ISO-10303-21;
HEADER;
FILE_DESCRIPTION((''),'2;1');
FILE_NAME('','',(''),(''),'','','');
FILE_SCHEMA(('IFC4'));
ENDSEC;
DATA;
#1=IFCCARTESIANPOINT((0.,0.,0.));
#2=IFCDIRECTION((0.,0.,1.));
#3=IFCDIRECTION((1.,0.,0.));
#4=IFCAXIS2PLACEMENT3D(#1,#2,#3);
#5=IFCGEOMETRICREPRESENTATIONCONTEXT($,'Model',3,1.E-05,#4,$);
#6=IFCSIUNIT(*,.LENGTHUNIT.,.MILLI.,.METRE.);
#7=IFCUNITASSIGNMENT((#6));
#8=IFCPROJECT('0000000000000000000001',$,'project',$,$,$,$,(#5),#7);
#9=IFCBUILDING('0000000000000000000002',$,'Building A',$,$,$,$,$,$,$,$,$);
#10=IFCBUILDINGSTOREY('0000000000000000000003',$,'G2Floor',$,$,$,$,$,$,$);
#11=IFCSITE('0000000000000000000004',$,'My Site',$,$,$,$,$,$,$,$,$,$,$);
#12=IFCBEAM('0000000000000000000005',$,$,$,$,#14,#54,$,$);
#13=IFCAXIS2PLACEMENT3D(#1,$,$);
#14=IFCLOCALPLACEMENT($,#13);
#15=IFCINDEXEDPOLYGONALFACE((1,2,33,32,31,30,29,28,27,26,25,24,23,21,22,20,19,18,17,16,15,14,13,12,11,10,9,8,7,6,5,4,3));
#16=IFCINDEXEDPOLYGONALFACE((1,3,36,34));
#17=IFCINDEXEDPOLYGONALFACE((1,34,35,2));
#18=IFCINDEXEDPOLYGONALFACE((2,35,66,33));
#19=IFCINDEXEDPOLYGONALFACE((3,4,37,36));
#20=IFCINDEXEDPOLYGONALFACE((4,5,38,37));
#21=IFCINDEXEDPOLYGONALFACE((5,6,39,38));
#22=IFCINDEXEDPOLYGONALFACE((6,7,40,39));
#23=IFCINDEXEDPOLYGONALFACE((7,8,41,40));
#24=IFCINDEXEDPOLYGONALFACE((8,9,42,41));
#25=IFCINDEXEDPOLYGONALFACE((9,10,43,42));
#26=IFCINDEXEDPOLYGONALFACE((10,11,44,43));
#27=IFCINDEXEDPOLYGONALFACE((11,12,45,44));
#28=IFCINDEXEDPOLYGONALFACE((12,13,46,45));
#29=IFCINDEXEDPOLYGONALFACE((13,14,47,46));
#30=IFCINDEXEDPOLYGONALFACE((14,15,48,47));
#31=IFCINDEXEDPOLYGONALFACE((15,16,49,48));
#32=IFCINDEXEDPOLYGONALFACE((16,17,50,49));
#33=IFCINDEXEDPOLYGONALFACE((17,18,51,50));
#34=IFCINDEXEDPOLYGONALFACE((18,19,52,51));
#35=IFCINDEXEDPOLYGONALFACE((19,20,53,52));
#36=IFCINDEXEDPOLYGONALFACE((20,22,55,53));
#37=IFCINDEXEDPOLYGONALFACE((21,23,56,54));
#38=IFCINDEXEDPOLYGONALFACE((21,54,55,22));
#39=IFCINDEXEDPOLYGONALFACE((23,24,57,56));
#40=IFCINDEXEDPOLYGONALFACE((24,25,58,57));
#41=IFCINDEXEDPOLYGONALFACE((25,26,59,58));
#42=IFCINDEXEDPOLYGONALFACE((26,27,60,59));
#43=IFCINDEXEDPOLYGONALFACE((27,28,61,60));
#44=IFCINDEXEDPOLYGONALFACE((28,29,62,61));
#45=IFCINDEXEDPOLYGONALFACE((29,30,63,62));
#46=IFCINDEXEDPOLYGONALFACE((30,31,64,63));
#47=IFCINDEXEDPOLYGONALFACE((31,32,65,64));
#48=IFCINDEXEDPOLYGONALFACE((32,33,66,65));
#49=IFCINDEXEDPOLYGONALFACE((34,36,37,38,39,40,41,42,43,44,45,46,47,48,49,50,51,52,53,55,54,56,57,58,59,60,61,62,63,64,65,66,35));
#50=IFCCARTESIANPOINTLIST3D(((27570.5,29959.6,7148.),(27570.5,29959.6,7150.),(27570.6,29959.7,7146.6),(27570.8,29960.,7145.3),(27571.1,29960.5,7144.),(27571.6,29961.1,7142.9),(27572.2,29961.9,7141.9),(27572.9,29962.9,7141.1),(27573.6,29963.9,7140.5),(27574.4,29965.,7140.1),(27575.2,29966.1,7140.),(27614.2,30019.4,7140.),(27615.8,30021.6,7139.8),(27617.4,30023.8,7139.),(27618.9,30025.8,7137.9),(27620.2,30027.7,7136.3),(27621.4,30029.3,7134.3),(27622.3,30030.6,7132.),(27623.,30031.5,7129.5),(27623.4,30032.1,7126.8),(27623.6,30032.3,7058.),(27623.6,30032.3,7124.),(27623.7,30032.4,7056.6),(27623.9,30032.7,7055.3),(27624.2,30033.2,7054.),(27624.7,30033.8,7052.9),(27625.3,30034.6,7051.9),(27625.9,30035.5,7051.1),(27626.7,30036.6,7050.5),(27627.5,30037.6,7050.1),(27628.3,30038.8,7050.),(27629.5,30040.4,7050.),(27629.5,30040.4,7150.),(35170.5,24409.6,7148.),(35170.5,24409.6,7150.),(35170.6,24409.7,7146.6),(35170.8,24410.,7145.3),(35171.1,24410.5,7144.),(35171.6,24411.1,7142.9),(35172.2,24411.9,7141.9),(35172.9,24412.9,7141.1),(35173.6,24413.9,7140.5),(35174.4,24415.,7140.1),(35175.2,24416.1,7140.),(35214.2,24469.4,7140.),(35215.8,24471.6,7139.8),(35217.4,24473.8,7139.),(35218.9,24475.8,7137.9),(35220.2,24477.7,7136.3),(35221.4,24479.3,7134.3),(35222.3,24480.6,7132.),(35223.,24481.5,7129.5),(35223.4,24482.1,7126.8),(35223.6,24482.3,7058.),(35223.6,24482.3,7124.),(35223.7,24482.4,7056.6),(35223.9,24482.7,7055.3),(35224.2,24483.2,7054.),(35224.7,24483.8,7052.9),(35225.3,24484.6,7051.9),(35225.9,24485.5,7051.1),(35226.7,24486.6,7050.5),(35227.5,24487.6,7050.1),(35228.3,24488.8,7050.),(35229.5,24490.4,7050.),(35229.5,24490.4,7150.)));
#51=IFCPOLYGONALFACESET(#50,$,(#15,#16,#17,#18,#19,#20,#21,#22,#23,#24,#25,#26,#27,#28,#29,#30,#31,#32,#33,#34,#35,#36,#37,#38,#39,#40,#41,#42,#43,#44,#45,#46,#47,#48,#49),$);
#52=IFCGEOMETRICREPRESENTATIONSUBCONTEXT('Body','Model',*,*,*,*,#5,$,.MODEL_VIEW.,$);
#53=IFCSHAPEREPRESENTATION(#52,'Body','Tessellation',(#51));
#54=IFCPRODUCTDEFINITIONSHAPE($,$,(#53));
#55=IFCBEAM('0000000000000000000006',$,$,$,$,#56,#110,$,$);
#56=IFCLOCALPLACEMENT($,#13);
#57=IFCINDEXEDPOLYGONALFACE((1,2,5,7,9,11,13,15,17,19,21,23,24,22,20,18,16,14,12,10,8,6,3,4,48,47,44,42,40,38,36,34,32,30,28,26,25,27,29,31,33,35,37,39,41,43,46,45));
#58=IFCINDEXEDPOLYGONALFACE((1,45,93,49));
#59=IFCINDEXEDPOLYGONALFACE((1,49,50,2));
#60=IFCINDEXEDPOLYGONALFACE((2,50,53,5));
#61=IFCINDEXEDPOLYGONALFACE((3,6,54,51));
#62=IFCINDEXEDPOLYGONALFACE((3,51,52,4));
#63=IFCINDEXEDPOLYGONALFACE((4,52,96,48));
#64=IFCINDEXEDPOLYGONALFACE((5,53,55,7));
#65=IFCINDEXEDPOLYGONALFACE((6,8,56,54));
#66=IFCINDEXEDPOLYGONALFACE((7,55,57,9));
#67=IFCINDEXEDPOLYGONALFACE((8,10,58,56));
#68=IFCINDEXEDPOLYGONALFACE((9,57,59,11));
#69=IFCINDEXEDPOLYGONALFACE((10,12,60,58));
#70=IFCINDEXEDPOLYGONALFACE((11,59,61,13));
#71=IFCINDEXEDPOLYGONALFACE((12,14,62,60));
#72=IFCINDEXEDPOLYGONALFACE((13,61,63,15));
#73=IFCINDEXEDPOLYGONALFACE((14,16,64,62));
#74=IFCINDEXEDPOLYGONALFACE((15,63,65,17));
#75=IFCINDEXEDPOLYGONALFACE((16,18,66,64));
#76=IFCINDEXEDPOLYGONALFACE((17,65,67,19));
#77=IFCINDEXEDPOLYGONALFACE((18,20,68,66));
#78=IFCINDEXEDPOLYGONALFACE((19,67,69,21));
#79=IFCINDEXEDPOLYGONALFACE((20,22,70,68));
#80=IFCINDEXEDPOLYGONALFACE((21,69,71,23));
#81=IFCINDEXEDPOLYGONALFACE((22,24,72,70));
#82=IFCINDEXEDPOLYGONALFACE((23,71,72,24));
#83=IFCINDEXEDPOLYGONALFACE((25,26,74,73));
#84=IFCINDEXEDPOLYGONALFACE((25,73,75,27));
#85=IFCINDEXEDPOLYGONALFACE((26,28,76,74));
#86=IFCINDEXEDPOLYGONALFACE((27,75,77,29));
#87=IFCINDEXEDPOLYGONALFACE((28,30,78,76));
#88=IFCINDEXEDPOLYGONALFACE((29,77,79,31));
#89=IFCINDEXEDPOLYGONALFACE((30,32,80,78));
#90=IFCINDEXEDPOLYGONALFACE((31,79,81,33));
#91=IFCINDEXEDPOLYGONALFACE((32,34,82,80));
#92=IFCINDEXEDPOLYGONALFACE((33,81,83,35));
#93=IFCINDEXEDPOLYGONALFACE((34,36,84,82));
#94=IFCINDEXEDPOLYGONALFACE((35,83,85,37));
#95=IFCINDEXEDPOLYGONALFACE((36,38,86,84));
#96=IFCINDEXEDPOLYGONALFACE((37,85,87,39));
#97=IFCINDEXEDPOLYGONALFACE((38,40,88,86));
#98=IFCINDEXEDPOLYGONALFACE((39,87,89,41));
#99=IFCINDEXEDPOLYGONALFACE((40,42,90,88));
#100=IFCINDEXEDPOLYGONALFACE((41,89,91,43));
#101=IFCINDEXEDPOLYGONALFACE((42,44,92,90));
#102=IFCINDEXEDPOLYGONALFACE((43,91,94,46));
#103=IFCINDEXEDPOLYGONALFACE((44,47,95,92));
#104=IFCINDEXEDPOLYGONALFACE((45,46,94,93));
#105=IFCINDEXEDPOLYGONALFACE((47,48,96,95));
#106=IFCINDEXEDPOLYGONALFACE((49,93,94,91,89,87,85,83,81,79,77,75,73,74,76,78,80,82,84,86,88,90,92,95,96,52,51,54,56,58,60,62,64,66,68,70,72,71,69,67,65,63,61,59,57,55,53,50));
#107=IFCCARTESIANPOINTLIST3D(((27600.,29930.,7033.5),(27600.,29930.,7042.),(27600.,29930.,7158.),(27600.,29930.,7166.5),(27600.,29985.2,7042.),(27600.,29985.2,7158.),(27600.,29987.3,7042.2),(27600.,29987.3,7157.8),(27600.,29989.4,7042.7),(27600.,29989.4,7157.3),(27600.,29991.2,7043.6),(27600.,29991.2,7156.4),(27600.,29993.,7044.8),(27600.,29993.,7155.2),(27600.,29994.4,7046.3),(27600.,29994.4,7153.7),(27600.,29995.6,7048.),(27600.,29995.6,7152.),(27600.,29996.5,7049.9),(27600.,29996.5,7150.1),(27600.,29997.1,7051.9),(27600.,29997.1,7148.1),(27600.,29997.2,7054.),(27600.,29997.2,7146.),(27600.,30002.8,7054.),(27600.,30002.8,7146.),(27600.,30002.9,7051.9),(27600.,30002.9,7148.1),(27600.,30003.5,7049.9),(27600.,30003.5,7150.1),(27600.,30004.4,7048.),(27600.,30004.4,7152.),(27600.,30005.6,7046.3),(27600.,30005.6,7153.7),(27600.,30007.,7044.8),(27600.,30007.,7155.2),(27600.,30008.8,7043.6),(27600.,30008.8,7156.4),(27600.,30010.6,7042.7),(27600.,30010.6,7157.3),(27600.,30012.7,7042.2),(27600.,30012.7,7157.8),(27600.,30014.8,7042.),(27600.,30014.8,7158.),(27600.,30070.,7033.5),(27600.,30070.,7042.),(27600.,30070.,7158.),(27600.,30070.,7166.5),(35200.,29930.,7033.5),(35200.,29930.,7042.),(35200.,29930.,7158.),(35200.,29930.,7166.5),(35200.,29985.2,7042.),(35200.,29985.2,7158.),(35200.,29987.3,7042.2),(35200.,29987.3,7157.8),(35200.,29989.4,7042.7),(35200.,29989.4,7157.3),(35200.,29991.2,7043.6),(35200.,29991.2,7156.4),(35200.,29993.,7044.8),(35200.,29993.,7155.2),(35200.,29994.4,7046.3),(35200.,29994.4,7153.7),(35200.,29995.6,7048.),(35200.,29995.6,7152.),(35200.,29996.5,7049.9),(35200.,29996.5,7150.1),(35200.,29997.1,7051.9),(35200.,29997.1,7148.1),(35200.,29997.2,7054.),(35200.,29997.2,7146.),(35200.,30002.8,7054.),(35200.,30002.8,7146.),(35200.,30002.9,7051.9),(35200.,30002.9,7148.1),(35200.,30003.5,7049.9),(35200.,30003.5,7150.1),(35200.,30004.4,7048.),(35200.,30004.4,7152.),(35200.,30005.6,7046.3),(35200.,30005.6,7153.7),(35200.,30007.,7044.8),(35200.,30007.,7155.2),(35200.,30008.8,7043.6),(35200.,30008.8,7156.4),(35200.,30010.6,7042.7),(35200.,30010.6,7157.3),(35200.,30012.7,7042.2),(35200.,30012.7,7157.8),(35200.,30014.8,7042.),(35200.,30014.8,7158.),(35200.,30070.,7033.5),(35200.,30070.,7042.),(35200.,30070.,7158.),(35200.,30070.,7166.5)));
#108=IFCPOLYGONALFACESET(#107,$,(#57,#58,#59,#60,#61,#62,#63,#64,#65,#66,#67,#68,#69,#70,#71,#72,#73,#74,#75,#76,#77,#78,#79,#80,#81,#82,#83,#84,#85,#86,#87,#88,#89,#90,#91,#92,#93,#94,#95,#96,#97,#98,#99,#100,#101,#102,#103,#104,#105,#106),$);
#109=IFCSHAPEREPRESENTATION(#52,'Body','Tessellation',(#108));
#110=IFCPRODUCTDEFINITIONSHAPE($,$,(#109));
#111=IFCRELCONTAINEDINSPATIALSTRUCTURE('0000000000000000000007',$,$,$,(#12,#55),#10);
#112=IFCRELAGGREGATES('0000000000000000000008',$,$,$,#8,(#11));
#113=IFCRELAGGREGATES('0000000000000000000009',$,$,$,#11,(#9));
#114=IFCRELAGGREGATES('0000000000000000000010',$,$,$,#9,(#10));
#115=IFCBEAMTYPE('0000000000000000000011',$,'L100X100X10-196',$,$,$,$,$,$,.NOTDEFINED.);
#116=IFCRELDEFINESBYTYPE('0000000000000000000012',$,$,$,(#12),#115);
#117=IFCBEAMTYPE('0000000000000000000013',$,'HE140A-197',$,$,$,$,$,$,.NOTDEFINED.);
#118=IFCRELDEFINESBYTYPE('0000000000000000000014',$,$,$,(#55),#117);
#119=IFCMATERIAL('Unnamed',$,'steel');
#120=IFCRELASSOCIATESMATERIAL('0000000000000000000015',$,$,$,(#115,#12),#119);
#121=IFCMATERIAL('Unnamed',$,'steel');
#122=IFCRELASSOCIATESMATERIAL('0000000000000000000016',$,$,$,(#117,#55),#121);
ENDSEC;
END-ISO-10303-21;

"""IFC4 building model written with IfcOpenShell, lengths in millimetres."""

from ifc_helpers import new_model, si_unit, frame, origin_with_axes, place, context, subcontext, project, spatial, polyline, outline, extrude, material, material_profile, profile_set, profile_usage, type_object, element, save


model = new_model("IFC4")

# Units and contexts
model_context = context("Model", 3, precision=1e-05, world=origin_with_axes())
body_context = subcontext(model_context, "Body", "Model", "MODEL_VIEW")
ifc_project = project(units=[si_unit("LENGTHUNIT", "METRE", prefix="MILLI")], contexts=[model_context])

# Site, building, storey
site = spatial("IfcSite", under=ifc_project, Name="My Site")
building = spatial("IfcBuilding", under=site, Name="Building A")
storey = spatial("IfcBuildingStorey", under=building, Name="G2Floor")

# Beams
ifc_material_1 = material(Name="Unnamed", Category="steel")
ifc_material_profile_1 = material_profile(ifc_material_1, outline(polyline([(-50.0, -50.0), (50.0, -50.0), (50.0, -50.0), (50.0, -48.0), (50.0, -48.0), (49.9, -46.6), (49.9, -46.6), (49.5, -45.3), (49.5, -45.3), (48.9, -44.0), (48.9, -44.0), (48.1, -42.9), (48.1, -42.9), (47.1, -41.9), (47.1, -41.9), (46.0, -41.1), (46.0, -41.1), (44.7, -40.5), (44.7, -40.5), (43.4, -40.1), (43.4, -40.1), (42.0, -40.0), (42.0, -40.0), (-24.0, -40.0), (-24.0, -40.0), (-26.8, -39.8), (-26.8, -39.8), (-29.5, -39.0), (-29.5, -39.0), (-32.0, -37.9), (-32.0, -37.9), (-34.3, -36.3), (-34.3, -36.3), (-36.3, -34.3), (-36.3, -34.3), (-37.9, -32.0), (-37.9, -32.0), (-39.0, -29.5), (-39.0, -29.5), (-39.8, -26.8), (-39.8, -26.8), (-40.0, -24.0), (-40.0, -24.0), (-40.0, 42.0), (-40.0, 42.0), (-40.1, 43.4), (-40.1, 43.4), (-40.5, 44.7), (-40.5, 44.7), (-41.1, 46.0), (-41.1, 46.0), (-41.9, 47.1), (-41.9, 47.1), (-42.9, 48.1), (-42.9, 48.1), (-44.0, 48.9), (-44.0, 48.9), (-45.3, 49.5), (-45.3, 49.5), (-46.6, 49.9), (-46.6, 49.9), (-48.0, 50.0), (-48.0, 50.0), (-50.0, 50.0), (-50.0, 50.0), (-50.0, -50.0)])))
ifc_profile_set_1 = profile_set([ifc_material_profile_1], Name="L100X100X10-196")
ifc_profile_usage_1 = profile_usage(ifc_profile_set_1)
beam_type_1 = type_object("IfcBeamType", Name="L100X100X10-196", PredefinedType="NOTDEFINED", material=ifc_profile_set_1)
beam_1_placement = place(None, frame((27600.0, 30000.0, 7100.0), z_axis=(0.807586, -0.58975, 0.0), x_axis=(-0.58975, -0.807586, 0.0)))
element("IfcBeam", 1, at=beam_1_placement, inside=storey, type_object=beam_type_1, material=ifc_profile_usage_1, context=body_context, shape_type="SweptSolid", body=[
    extrude(outline(polyline([(-50.0, -50.0), (50.0, -50.0), (50.0, -50.0), (50.0, -48.0), (50.0, -48.0), (49.9, -46.6), (49.9, -46.6), (49.5, -45.3), (49.5, -45.3), (48.9, -44.0), (48.9, -44.0), (48.1, -42.9), (48.1, -42.9), (47.1, -41.9), (47.1, -41.9), (46.0, -41.1), (46.0, -41.1), (44.7, -40.5), (44.7, -40.5), (43.4, -40.1), (43.4, -40.1), (42.0, -40.0), (42.0, -40.0), (-24.0, -40.0), (-24.0, -40.0), (-26.8, -39.8), (-26.8, -39.8), (-29.5, -39.0), (-29.5, -39.0), (-32.0, -37.9), (-32.0, -37.9), (-34.3, -36.3), (-34.3, -36.3), (-36.3, -34.3), (-36.3, -34.3), (-37.9, -32.0), (-37.9, -32.0), (-39.0, -29.5), (-39.0, -29.5), (-39.8, -26.8), (-39.8, -26.8), (-40.0, -24.0), (-40.0, -24.0), (-40.0, 42.0), (-40.0, 42.0), (-40.1, 43.4), (-40.1, 43.4), (-40.5, 44.7), (-40.5, 44.7), (-41.1, 46.0), (-41.1, 46.0), (-41.9, 47.1), (-41.9, 47.1), (-42.9, 48.1), (-42.9, 48.1), (-44.0, 48.9), (-44.0, 48.9), (-45.3, 49.5), (-45.3, 49.5), (-46.6, 49.9), (-46.6, 49.9), (-48.0, 50.0), (-48.0, 50.0), (-50.0, 50.0), (-50.0, 50.0), (-50.0, -50.0)])), origin_with_axes(), (0.0, 0.0, 1.0), 9410.8),
])
ifc_material_2 = material(Name="Unnamed", Category="steel")
ifc_material_profile_2 = material_profile(ifc_material_2, outline(polyline([(70.0, -66.5), (70.0, -58.0), (70.0, -58.0), (14.8, -58.0), (14.8, -58.0), (12.7, -57.8), (12.7, -57.8), (10.6, -57.3), (10.6, -57.3), (8.8, -56.4), (8.8, -56.4), (7.0, -55.2), (7.0, -55.2), (5.6, -53.7), (5.6, -53.7), (4.4, -52.0), (4.4, -52.0), (3.5, -50.1), (3.5, -50.1), (2.9, -48.1), (2.9, -48.1), (2.8, -46.0), (2.8, -46.0), (2.8, 46.0), (2.8, 46.0), (2.9, 48.1), (2.9, 48.1), (3.5, 50.1), (3.5, 50.1), (4.4, 52.0), (4.4, 52.0), (5.6, 53.7), (5.6, 53.7), (7.0, 55.2), (7.0, 55.2), (8.8, 56.4), (8.8, 56.4), (10.6, 57.3), (10.6, 57.3), (12.7, 57.8), (12.7, 57.8), (14.8, 58.0), (14.8, 58.0), (70.0, 58.0), (70.0, 58.0), (70.0, 66.5), (70.0, 66.5), (-70.0, 66.5), (-70.0, 66.5), (-70.0, 58.0), (-70.0, 58.0), (-14.8, 58.0), (-14.8, 58.0), (-12.7, 57.8), (-12.7, 57.8), (-10.6, 57.3), (-10.6, 57.3), (-8.8, 56.4), (-8.8, 56.4), (-7.0, 55.2), (-7.0, 55.2), (-5.6, 53.7), (-5.6, 53.7), (-4.4, 52.0), (-4.4, 52.0), (-3.5, 50.1), (-3.5, 50.1), (-2.9, 48.1), (-2.9, 48.1), (-2.8, 46.0), (-2.8, 46.0), (-2.8, -46.0), (-2.8, -46.0), (-2.9, -48.1), (-2.9, -48.1), (-3.5, -50.1), (-3.5, -50.1), (-4.4, -52.0), (-4.4, -52.0), (-5.6, -53.7), (-5.6, -53.7), (-7.0, -55.2), (-7.0, -55.2), (-8.8, -56.4), (-8.8, -56.4), (-10.6, -57.3), (-10.6, -57.3), (-12.7, -57.8), (-12.7, -57.8), (-14.8, -58.0), (-14.8, -58.0), (-70.0, -58.0), (-70.0, -58.0), (-70.0, -66.5), (-70.0, -66.5), (70.0, -66.5)])))
ifc_profile_set_2 = profile_set([ifc_material_profile_2], Name="HE140A-197")
ifc_profile_usage_2 = profile_usage(ifc_profile_set_2)
beam_type_2 = type_object("IfcBeamType", Name="HE140A-197", PredefinedType="NOTDEFINED", material=ifc_profile_set_2)
beam_2_placement = place(None, frame((27600.0, 30000.0, 7100.0), z_axis=(1.0, 0.0, 0.0), x_axis=(0.0, -1.0, 0.0)))
element("IfcBeam", 2, at=beam_2_placement, inside=storey, type_object=beam_type_2, material=ifc_profile_usage_2, context=body_context, shape_type="SweptSolid", body=[
    extrude(outline(polyline([(70.0, -66.5), (70.0, -58.0), (70.0, -58.0), (14.8, -58.0), (14.8, -58.0), (12.7, -57.8), (12.7, -57.8), (10.6, -57.3), (10.6, -57.3), (8.8, -56.4), (8.8, -56.4), (7.0, -55.2), (7.0, -55.2), (5.6, -53.7), (5.6, -53.7), (4.4, -52.0), (4.4, -52.0), (3.5, -50.1), (3.5, -50.1), (2.9, -48.1), (2.9, -48.1), (2.8, -46.0), (2.8, -46.0), (2.8, 46.0), (2.8, 46.0), (2.9, 48.1), (2.9, 48.1), (3.5, 50.1), (3.5, 50.1), (4.4, 52.0), (4.4, 52.0), (5.6, 53.7), (5.6, 53.7), (7.0, 55.2), (7.0, 55.2), (8.8, 56.4), (8.8, 56.4), (10.6, 57.3), (10.6, 57.3), (12.7, 57.8), (12.7, 57.8), (14.8, 58.0), (14.8, 58.0), (70.0, 58.0), (70.0, 58.0), (70.0, 66.5), (70.0, 66.5), (-70.0, 66.5), (-70.0, 66.5), (-70.0, 58.0), (-70.0, 58.0), (-14.8, 58.0), (-14.8, 58.0), (-12.7, 57.8), (-12.7, 57.8), (-10.6, 57.3), (-10.6, 57.3), (-8.8, 56.4), (-8.8, 56.4), (-7.0, 55.2), (-7.0, 55.2), (-5.6, 53.7), (-5.6, 53.7), (-4.4, 52.0), (-4.4, 52.0), (-3.5, 50.1), (-3.5, 50.1), (-2.9, 48.1), (-2.9, 48.1), (-2.8, 46.0), (-2.8, 46.0), (-2.8, -46.0), (-2.8, -46.0), (-2.9, -48.1), (-2.9, -48.1), (-3.5, -50.1), (-3.5, -50.1), (-4.4, -52.0), (-4.4, -52.0), (-5.6, -53.7), (-5.6, -53.7), (-7.0, -55.2), (-7.0, -55.2), (-8.8, -56.4), (-8.8, -56.4), (-10.6, -57.3), (-10.6, -57.3), (-12.7, -57.8), (-12.7, -57.8), (-14.8, -58.0), (-14.8, -58.0), (-70.0, -58.0), (-70.0, -58.0), (-70.0, -66.5), (-70.0, -66.5), (70.0, -66.5)])), origin_with_axes(), (0.0, 0.0, 1.0), 7600.0),
])

save(model, "model.ifc")
